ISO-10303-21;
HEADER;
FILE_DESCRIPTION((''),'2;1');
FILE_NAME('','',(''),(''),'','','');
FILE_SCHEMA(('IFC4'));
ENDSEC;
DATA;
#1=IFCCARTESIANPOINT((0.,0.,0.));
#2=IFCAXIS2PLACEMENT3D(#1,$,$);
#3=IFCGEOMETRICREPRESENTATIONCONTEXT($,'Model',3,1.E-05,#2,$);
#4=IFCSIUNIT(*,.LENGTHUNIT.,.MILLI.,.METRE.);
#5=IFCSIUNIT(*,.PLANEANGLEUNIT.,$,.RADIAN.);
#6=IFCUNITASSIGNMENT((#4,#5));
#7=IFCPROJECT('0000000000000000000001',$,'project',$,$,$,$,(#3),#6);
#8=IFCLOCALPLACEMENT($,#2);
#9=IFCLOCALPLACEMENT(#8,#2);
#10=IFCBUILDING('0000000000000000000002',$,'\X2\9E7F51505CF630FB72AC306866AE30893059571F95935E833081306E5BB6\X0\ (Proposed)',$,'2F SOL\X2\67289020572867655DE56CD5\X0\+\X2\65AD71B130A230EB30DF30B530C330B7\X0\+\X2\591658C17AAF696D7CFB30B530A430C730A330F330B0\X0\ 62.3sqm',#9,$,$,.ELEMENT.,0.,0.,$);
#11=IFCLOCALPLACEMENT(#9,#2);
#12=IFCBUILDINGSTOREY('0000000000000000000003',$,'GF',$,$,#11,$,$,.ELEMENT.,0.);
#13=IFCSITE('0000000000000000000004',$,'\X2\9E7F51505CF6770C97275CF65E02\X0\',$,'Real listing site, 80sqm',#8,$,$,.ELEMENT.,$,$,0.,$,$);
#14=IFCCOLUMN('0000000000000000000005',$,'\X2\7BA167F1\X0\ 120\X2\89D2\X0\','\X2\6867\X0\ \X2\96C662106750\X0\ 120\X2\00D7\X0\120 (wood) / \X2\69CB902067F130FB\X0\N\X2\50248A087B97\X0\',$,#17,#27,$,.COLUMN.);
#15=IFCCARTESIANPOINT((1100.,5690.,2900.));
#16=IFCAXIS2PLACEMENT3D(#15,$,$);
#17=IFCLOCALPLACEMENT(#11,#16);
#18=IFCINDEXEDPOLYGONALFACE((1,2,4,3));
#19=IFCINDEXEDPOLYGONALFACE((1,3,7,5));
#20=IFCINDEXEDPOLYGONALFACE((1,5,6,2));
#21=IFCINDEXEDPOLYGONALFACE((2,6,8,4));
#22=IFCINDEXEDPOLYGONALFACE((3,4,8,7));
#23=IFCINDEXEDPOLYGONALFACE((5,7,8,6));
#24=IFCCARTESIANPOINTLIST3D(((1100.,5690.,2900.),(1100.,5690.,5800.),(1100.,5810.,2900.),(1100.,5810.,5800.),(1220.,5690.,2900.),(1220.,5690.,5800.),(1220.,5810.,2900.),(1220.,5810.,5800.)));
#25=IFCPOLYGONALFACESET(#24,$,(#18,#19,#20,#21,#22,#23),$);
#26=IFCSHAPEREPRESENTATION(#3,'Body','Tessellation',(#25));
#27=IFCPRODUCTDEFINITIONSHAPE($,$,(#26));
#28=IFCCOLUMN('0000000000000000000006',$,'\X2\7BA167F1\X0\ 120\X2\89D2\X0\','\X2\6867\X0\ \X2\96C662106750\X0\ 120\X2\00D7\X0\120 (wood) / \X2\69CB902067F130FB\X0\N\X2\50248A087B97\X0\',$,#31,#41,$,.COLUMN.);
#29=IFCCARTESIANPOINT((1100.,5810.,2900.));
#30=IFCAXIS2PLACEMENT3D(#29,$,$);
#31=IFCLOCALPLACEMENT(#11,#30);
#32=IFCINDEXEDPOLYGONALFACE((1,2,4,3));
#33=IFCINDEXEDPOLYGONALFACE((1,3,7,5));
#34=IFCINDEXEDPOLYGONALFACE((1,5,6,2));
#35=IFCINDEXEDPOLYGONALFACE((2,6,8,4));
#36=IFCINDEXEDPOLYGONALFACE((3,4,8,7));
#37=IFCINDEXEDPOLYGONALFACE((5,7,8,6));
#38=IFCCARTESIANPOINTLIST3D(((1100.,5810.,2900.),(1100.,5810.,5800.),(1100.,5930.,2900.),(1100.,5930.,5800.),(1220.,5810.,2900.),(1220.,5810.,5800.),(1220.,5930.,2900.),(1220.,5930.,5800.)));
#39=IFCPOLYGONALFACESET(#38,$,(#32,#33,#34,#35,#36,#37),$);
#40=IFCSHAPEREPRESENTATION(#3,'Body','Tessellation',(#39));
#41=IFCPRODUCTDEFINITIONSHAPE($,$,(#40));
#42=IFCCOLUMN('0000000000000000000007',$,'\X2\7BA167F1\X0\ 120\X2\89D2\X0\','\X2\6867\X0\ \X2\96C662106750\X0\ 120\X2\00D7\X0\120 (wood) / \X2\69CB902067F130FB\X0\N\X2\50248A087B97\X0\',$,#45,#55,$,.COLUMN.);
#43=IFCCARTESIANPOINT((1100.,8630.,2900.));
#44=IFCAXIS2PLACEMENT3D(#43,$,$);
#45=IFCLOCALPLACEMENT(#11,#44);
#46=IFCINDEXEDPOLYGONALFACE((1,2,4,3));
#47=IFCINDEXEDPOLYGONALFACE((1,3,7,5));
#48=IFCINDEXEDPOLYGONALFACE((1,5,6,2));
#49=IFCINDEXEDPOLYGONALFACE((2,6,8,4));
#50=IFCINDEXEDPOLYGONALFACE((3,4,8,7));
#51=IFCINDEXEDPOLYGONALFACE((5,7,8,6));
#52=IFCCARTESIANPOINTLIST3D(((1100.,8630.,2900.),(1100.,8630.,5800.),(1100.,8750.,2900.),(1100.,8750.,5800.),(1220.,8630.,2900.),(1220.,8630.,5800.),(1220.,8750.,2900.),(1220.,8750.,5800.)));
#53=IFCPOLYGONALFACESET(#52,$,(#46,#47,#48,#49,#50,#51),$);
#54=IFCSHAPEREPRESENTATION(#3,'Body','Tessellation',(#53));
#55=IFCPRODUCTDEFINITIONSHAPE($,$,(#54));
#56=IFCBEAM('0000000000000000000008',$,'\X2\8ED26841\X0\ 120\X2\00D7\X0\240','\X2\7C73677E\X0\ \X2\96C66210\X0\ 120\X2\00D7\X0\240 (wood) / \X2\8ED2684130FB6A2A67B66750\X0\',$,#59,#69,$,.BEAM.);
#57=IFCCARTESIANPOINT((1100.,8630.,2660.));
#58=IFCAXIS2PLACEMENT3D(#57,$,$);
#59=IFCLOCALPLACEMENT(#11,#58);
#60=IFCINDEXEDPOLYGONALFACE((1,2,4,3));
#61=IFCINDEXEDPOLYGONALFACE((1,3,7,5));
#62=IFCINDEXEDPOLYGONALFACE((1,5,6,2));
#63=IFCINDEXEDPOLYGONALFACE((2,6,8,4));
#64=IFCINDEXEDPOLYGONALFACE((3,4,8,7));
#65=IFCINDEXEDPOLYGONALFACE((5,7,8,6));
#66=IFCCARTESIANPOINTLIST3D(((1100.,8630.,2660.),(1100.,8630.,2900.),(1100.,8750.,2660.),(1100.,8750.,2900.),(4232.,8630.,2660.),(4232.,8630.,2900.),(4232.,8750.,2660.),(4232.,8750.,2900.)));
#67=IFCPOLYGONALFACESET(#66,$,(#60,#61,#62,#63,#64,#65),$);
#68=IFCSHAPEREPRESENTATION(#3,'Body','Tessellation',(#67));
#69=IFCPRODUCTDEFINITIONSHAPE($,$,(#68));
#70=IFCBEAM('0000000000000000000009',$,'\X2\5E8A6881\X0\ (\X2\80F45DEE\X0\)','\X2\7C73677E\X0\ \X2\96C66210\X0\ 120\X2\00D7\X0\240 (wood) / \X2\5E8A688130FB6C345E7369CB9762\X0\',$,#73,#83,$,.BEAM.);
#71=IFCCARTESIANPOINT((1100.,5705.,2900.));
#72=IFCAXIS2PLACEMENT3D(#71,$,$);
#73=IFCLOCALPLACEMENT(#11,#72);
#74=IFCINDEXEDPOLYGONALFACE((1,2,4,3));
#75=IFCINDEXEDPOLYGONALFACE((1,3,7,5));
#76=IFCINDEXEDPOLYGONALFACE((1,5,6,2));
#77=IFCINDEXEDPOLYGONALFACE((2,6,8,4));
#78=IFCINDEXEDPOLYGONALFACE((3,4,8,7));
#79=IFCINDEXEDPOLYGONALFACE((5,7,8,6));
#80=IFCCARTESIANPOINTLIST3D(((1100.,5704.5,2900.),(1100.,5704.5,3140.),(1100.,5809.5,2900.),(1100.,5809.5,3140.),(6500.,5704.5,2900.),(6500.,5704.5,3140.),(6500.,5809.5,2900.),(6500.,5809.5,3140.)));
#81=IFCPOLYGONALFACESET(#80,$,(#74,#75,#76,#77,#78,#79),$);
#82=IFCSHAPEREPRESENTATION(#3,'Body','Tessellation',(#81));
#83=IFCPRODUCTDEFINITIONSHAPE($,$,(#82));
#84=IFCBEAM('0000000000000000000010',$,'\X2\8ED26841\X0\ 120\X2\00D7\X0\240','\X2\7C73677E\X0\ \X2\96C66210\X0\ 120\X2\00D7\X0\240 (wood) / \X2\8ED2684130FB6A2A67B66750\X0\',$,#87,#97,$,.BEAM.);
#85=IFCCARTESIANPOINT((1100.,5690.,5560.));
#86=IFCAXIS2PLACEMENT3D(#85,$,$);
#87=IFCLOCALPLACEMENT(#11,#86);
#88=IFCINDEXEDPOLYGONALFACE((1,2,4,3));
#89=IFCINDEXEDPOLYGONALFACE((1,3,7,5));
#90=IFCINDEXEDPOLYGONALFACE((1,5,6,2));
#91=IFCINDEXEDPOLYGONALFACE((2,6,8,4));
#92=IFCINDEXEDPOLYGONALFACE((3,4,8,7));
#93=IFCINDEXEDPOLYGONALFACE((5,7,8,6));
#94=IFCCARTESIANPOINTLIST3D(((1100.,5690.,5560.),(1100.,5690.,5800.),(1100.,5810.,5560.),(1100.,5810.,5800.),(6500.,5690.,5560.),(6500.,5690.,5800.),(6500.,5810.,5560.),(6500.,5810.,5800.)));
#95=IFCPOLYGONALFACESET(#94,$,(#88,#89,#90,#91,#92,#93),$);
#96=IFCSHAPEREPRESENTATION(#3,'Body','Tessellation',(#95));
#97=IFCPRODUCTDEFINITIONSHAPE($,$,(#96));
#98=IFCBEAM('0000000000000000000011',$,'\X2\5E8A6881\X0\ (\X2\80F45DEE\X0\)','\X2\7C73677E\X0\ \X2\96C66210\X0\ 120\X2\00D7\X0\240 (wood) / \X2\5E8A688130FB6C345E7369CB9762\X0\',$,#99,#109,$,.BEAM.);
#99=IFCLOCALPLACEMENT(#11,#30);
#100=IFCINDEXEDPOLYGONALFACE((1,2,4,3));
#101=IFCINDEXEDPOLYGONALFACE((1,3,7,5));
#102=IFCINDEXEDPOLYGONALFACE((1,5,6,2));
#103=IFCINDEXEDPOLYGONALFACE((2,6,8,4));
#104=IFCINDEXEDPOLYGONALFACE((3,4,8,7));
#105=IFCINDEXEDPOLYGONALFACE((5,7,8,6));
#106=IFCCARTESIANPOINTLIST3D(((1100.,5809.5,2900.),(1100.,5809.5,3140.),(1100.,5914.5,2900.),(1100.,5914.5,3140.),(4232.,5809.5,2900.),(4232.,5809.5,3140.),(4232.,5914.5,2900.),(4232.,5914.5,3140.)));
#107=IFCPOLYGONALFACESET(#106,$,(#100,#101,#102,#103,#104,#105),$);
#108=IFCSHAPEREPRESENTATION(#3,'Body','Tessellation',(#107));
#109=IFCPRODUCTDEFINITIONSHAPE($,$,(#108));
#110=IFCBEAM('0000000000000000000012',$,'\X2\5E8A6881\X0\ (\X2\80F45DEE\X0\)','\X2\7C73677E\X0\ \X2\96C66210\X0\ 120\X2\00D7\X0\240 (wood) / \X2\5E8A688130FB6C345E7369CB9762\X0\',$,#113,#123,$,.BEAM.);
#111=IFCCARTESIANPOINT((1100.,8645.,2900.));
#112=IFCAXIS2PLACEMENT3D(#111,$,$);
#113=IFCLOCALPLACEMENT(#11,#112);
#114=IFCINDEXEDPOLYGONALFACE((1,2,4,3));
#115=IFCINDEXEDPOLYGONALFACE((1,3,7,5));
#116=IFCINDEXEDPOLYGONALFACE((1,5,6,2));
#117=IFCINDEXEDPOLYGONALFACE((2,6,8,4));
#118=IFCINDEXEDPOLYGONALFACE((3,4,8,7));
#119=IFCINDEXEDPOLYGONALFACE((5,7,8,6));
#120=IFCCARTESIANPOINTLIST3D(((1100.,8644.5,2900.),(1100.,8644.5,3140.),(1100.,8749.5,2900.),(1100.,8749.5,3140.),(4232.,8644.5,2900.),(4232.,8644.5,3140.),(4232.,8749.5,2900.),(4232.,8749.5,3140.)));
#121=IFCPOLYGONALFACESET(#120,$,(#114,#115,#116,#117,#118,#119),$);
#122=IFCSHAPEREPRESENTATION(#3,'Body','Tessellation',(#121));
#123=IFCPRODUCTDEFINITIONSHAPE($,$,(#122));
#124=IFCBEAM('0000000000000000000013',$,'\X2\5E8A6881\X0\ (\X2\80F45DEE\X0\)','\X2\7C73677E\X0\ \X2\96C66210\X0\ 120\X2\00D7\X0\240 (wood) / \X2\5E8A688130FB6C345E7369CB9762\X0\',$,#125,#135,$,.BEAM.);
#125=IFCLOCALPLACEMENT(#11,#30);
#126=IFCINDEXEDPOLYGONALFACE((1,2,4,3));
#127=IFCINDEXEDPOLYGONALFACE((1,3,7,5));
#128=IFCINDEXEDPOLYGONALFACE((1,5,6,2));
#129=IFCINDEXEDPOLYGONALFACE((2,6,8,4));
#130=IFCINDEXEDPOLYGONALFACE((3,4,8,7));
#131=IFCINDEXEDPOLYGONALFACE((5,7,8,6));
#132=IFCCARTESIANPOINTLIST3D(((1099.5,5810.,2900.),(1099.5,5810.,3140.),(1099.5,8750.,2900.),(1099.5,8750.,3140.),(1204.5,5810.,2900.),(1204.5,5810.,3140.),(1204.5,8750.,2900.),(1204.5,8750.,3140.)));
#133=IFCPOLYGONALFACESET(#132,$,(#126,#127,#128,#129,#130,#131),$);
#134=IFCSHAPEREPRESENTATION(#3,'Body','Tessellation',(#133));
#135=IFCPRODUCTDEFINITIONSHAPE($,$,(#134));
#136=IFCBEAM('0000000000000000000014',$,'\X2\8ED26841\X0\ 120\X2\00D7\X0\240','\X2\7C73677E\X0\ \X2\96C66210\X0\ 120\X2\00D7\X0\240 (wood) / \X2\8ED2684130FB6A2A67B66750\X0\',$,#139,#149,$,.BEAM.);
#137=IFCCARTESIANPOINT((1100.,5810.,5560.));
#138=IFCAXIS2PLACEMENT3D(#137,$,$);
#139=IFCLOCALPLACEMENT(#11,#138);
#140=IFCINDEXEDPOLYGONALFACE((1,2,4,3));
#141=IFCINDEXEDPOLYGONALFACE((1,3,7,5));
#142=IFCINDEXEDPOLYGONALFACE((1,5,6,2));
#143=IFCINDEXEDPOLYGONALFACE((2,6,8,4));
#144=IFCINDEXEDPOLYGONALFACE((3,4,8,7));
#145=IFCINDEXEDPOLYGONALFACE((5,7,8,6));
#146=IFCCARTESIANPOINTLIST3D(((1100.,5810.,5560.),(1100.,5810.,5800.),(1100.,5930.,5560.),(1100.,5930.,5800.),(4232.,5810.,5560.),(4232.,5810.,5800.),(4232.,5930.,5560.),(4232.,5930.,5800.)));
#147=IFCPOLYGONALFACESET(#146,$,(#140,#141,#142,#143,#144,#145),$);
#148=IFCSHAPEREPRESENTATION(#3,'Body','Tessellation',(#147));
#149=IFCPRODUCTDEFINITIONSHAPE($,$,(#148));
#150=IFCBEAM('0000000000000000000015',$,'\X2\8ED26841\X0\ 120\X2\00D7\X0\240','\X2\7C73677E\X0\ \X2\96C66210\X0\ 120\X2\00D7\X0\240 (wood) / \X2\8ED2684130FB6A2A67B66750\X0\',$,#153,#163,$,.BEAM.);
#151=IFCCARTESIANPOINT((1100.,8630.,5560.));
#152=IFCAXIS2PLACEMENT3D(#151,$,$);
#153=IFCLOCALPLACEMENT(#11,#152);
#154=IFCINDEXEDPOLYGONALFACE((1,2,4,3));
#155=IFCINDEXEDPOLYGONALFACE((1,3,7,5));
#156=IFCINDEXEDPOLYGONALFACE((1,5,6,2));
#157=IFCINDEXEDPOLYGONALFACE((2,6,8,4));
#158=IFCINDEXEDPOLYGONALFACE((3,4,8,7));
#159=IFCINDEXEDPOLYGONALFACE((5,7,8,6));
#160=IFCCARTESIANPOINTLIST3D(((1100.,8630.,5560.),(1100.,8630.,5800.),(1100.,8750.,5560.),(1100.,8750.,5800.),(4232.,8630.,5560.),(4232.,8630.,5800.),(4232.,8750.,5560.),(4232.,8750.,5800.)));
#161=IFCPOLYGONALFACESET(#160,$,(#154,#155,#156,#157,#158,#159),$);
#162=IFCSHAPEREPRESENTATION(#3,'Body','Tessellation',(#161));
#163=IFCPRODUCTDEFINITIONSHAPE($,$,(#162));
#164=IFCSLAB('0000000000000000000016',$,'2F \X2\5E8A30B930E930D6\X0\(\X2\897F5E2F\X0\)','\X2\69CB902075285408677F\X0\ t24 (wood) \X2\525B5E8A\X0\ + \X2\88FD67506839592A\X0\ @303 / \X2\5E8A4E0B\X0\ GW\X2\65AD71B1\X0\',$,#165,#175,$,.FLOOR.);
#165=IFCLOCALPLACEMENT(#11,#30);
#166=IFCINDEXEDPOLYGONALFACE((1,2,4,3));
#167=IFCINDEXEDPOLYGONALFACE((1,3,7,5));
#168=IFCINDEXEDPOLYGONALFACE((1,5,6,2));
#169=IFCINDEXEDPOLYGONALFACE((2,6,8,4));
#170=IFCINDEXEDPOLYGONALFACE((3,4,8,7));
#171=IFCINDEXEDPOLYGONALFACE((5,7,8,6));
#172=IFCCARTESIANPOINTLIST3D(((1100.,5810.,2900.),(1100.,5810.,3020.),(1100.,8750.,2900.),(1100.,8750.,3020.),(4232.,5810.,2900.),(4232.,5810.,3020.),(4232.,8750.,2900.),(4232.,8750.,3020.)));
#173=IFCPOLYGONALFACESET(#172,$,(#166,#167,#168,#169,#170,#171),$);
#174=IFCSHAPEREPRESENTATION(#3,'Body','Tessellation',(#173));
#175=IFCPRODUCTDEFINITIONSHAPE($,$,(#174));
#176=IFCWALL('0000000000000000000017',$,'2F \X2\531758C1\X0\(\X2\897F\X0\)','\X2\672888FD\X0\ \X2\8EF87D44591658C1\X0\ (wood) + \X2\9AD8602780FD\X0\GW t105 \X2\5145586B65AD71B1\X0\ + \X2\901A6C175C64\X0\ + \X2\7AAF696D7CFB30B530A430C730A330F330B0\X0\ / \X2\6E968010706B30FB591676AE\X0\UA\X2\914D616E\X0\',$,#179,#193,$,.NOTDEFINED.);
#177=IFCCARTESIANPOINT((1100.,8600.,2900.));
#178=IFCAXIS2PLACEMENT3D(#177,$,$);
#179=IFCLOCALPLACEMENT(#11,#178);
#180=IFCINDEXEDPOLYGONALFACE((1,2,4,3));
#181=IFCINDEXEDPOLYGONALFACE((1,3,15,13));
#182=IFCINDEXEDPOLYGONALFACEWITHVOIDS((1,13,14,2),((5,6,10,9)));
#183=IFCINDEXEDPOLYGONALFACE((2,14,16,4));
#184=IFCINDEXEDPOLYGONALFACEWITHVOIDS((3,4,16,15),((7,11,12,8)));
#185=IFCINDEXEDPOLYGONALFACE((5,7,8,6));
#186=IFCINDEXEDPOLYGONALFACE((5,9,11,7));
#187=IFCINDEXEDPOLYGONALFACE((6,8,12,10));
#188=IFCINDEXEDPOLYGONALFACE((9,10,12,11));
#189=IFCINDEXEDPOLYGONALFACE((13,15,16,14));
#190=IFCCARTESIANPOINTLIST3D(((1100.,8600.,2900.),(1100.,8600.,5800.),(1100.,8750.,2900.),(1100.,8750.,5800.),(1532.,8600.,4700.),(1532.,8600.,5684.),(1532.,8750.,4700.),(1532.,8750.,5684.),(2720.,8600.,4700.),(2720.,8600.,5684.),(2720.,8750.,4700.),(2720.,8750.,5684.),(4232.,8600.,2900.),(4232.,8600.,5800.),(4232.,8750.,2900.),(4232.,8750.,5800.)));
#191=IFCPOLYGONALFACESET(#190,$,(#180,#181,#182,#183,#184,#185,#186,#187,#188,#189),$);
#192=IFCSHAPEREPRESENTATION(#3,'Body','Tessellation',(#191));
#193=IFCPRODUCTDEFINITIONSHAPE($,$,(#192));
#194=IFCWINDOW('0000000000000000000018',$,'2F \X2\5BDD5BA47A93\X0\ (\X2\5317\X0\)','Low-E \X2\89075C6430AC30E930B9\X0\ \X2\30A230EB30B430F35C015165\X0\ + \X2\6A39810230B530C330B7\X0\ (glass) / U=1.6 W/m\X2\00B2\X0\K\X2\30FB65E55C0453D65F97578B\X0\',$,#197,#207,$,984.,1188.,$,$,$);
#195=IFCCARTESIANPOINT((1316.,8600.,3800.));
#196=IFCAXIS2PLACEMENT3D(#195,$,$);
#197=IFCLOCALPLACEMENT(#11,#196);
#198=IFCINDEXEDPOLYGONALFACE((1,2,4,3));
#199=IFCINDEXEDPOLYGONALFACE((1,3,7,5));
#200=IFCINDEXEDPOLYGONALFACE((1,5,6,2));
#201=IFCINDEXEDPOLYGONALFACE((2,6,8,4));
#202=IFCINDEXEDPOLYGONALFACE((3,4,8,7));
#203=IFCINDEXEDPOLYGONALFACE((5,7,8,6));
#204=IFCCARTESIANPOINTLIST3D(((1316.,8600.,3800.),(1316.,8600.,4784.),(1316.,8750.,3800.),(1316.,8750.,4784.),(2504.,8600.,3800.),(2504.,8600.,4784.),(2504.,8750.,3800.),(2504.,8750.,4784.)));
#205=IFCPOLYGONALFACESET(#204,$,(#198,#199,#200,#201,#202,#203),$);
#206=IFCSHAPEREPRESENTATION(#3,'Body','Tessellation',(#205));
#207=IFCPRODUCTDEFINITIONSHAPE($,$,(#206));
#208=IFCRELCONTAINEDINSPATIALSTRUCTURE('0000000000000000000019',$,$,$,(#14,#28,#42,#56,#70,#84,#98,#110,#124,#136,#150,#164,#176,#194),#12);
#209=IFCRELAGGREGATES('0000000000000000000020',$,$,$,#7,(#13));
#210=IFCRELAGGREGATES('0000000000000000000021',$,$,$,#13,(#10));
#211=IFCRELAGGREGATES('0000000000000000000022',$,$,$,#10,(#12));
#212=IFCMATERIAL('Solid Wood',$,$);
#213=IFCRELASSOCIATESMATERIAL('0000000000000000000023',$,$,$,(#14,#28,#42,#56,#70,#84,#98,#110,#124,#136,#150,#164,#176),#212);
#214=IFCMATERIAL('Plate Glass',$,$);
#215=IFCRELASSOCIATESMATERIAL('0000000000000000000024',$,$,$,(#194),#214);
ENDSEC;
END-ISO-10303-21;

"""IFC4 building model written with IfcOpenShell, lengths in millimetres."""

from ifc_helpers import new_model, si_unit, frame, frame_2d, origin, place, context, project, spatial, rectangle, extrude, material, element, fill, save


model = new_model("IFC4")

# Units and contexts
model_context = context("Model", 3, precision=1e-05, world=origin())
ifc_project = project(units=[si_unit("LENGTHUNIT", "METRE", prefix="MILLI"), si_unit("PLANEANGLEUNIT", "RADIAN")], contexts=[model_context])

# Site, building, storey
site_placement = place(None, origin())
site = spatial("IfcSite", under=ifc_project, at=site_placement, Name="鹿児島県霧島市", ObjectType="Real listing site, 80sqm", CompositionType="ELEMENT", RefElevation=0.0)
building_placement = place(site_placement, origin())
building = spatial("IfcBuilding", under=site, at=building_placement, Name="鹿児島・犬と暮らす土間広めの家 (Proposed)", ObjectType="2F SOL木造在来工法+断熱アルミサッシ+外壁窯業系サイディング 62.3sqm", CompositionType="ELEMENT", ElevationOfRefHeight=0.0, ElevationOfTerrain=0.0)
storey_placement = place(building_placement, origin())
storey = spatial("IfcBuildingStorey", under=building, at=storey_placement, Name="GF", CompositionType="ELEMENT", Elevation=0.0)

# Columns
ifc_material_1 = material(Name="Solid Wood")
column_1_placement = place(storey_placement, frame((1100.0, 5690.0, 2900.0)))
element("IfcColumn", 1, at=column_1_placement, inside=storey, material=ifc_material_1, Name="管柱 120角", Description="桧 集成材 120×120 (wood) / 構造柱・N値計算", PredefinedType="COLUMN", context=model_context, shape_type="SweptSolid", body=[
    extrude(rectangle(XDim=120.0, YDim=120.0, at=frame_2d((60.0, 60.0))), frame((1100.0, 5690.0, 2900.0)), (0.0, 0.0, 1.0), 2900.0),
])
column_2_placement = place(storey_placement, frame((1100.0, 5810.0, 2900.0)))
element("IfcColumn", 2, at=column_2_placement, inside=storey, material=ifc_material_1, Name="管柱 120角", Description="桧 集成材 120×120 (wood) / 構造柱・N値計算", PredefinedType="COLUMN", context=model_context, shape_type="SweptSolid", body=[
    extrude(rectangle(XDim=120.0, YDim=120.0, at=frame_2d((60.0, 60.0))), frame((1100.0, 5810.0, 2900.0)), (0.0, 0.0, 1.0), 2900.0),
])
column_3_placement = place(storey_placement, frame((1100.0, 8630.0, 2900.0)))
element("IfcColumn", 3, at=column_3_placement, inside=storey, material=ifc_material_1, Name="管柱 120角", Description="桧 集成材 120×120 (wood) / 構造柱・N値計算", PredefinedType="COLUMN", context=model_context, shape_type="SweptSolid", body=[
    extrude(rectangle(XDim=120.0, YDim=120.0, at=frame_2d((60.0, 60.0))), frame((1100.0, 8630.0, 2900.0)), (0.0, 0.0, 1.0), 2900.0),
])

# Beams
beam_1_placement = place(storey_placement, frame((1100.0, 8630.0, 2660.0)))
element("IfcBeam", 4, at=beam_1_placement, inside=storey, material=ifc_material_1, Name="軒桁 120×240", Description="米松 集成 120×240 (wood) / 軒桁・横架材", PredefinedType="BEAM", context=model_context, shape_type="SweptSolid", body=[
    extrude(rectangle(XDim=3132.0, YDim=120.0, at=frame_2d((1566.0, 60.0))), frame((1100.0, 8630.0, 2660.0)), (0.0, 0.0, 1.0), 240.0),
])
beam_2_placement = place(storey_placement, frame((1100.0, 5705.0, 2900.0)))
element("IfcBeam", 5, at=beam_2_placement, inside=storey, material=ifc_material_1, Name="床梁 (胴差)", Description="米松 集成 120×240 (wood) / 床梁・水平構面", PredefinedType="BEAM", context=model_context, shape_type="SweptSolid", body=[
    extrude(rectangle(XDim=5400.0, YDim=105.0, at=frame_2d((2700.0, 52.0))), frame((1100.0, 5705.0, 2900.0)), (0.0, 0.0, 1.0), 240.0),
])
beam_3_placement = place(storey_placement, frame((1100.0, 5690.0, 5560.0)))
element("IfcBeam", 6, at=beam_3_placement, inside=storey, material=ifc_material_1, Name="軒桁 120×240", Description="米松 集成 120×240 (wood) / 軒桁・横架材", PredefinedType="BEAM", context=model_context, shape_type="SweptSolid", body=[
    extrude(rectangle(XDim=5400.0, YDim=120.0, at=frame_2d((2700.0, 60.0))), frame((1100.0, 5690.0, 5560.0)), (0.0, 0.0, 1.0), 240.0),
])
beam_4_placement = place(storey_placement, frame((1100.0, 5810.0, 2900.0)))
element("IfcBeam", 7, at=beam_4_placement, inside=storey, material=ifc_material_1, Name="床梁 (胴差)", Description="米松 集成 120×240 (wood) / 床梁・水平構面", PredefinedType="BEAM", context=model_context, shape_type="SweptSolid", body=[
    extrude(rectangle(XDim=3132.0, YDim=105.0, at=frame_2d((1566.0, 52.0))), frame((1100.0, 5810.0, 2900.0)), (0.0, 0.0, 1.0), 240.0),
])
beam_5_placement = place(storey_placement, frame((1100.0, 8645.0, 2900.0)))
element("IfcBeam", 8, at=beam_5_placement, inside=storey, material=ifc_material_1, Name="床梁 (胴差)", Description="米松 集成 120×240 (wood) / 床梁・水平構面", PredefinedType="BEAM", context=model_context, shape_type="SweptSolid", body=[
    extrude(rectangle(XDim=3132.0, YDim=105.0, at=frame_2d((1566.0, 52.0))), frame((1100.0, 8645.0, 2900.0)), (0.0, 0.0, 1.0), 240.0),
])
beam_6_placement = place(storey_placement, frame((1100.0, 5810.0, 2900.0)))
element("IfcBeam", 9, at=beam_6_placement, inside=storey, material=ifc_material_1, Name="床梁 (胴差)", Description="米松 集成 120×240 (wood) / 床梁・水平構面", PredefinedType="BEAM", context=model_context, shape_type="SweptSolid", body=[
    extrude(rectangle(XDim=105.0, YDim=2940.0, at=frame_2d((52.0, 1470.0))), frame((1100.0, 5810.0, 2900.0)), (0.0, 0.0, 1.0), 240.0),
])
beam_7_placement = place(storey_placement, frame((1100.0, 5810.0, 5560.0)))
element("IfcBeam", 10, at=beam_7_placement, inside=storey, material=ifc_material_1, Name="軒桁 120×240", Description="米松 集成 120×240 (wood) / 軒桁・横架材", PredefinedType="BEAM", context=model_context, shape_type="SweptSolid", body=[
    extrude(rectangle(XDim=3132.0, YDim=120.0, at=frame_2d((1566.0, 60.0))), frame((1100.0, 5810.0, 5560.0)), (0.0, 0.0, 1.0), 240.0),
])
beam_8_placement = place(storey_placement, frame((1100.0, 8630.0, 5560.0)))
element("IfcBeam", 11, at=beam_8_placement, inside=storey, material=ifc_material_1, Name="軒桁 120×240", Description="米松 集成 120×240 (wood) / 軒桁・横架材", PredefinedType="BEAM", context=model_context, shape_type="SweptSolid", body=[
    extrude(rectangle(XDim=3132.0, YDim=120.0, at=frame_2d((1566.0, 60.0))), frame((1100.0, 8630.0, 5560.0)), (0.0, 0.0, 1.0), 240.0),
])

# Slab
slab_placement = place(storey_placement, frame((1100.0, 5810.0, 2900.0)))
element("IfcSlab", 12, at=slab_placement, inside=storey, material=ifc_material_1, Name="2F 床スラブ(西帯)", Description="構造用合板 t24 (wood) 剛床 + 製材根太 @303 / 床下 GW断熱", PredefinedType="FLOOR", context=model_context, shape_type="SweptSolid", body=[
    extrude(rectangle(XDim=3132.0, YDim=2940.0, at=frame_2d((1566.0, 1470.0))), frame((1100.0, 5810.0, 2900.0)), (0.0, 0.0, 1.0), 120.0),
])

# Wall, opening, window
wall_1_placement = place(storey_placement, frame((1100.0, 8600.0, 2900.0)))
wall_1 = element("IfcWall", 13, at=wall_1_placement, inside=storey, material=ifc_material_1, Name="2F 北壁(西)", Description="木製 軸組外壁 (wood) + 高性能GW t105 充填断熱 + 通気層 + 窯業系サイディング / 準耐火・外皮UA配慮", PredefinedType="NOTDEFINED", context=model_context, shape_type="SweptSolid", body=[
    extrude(rectangle(XDim=3132.0, YDim=150.0, at=frame_2d((1566.0, 75.0))), frame((1100.0, 8600.0, 2900.0)), (0.0, 0.0, 1.0), 2900.0),
])
opening_placement = place(storey_placement, frame((1316.0, 8600.0, 3800.0)))
opening = element("IfcOpeningElement", 14, at=opening_placement, cuts=wall_1, PredefinedType="NOTDEFINED", context=model_context, shape_type="SweptSolid", body=[
    extrude(rectangle(XDim=1188.0, YDim=150.0, at=frame_2d((594.0, 75.0))), frame((1316.0, 8600.0, 3800.0)), (0.0, 0.0, 1.0), 984.0),
])
ifc_material_2 = material(Name="Plate Glass")
window_placement = place(storey_placement, frame((1316.0, 8600.0, 3800.0)))
window = element("IfcWindow", 15, at=window_placement, inside=storey, material=ifc_material_2, Name="2F 寝室窓 (北)", Description="Low-E 複層ガラス アルゴン封入 + 樹脂サッシ (glass) / U=1.6 W/m²K・日射取得型", OverallHeight=984.0, OverallWidth=1188.0, context=model_context, shape_type="SweptSolid", body=[
    extrude(rectangle(XDim=1188.0, YDim=150.0, at=frame_2d((594.0, 75.0))), frame((1316.0, 8600.0, 3800.0)), (0.0, 0.0, 1.0), 984.0),
])
fill(opening, window)

save(model, "model.ifc")
